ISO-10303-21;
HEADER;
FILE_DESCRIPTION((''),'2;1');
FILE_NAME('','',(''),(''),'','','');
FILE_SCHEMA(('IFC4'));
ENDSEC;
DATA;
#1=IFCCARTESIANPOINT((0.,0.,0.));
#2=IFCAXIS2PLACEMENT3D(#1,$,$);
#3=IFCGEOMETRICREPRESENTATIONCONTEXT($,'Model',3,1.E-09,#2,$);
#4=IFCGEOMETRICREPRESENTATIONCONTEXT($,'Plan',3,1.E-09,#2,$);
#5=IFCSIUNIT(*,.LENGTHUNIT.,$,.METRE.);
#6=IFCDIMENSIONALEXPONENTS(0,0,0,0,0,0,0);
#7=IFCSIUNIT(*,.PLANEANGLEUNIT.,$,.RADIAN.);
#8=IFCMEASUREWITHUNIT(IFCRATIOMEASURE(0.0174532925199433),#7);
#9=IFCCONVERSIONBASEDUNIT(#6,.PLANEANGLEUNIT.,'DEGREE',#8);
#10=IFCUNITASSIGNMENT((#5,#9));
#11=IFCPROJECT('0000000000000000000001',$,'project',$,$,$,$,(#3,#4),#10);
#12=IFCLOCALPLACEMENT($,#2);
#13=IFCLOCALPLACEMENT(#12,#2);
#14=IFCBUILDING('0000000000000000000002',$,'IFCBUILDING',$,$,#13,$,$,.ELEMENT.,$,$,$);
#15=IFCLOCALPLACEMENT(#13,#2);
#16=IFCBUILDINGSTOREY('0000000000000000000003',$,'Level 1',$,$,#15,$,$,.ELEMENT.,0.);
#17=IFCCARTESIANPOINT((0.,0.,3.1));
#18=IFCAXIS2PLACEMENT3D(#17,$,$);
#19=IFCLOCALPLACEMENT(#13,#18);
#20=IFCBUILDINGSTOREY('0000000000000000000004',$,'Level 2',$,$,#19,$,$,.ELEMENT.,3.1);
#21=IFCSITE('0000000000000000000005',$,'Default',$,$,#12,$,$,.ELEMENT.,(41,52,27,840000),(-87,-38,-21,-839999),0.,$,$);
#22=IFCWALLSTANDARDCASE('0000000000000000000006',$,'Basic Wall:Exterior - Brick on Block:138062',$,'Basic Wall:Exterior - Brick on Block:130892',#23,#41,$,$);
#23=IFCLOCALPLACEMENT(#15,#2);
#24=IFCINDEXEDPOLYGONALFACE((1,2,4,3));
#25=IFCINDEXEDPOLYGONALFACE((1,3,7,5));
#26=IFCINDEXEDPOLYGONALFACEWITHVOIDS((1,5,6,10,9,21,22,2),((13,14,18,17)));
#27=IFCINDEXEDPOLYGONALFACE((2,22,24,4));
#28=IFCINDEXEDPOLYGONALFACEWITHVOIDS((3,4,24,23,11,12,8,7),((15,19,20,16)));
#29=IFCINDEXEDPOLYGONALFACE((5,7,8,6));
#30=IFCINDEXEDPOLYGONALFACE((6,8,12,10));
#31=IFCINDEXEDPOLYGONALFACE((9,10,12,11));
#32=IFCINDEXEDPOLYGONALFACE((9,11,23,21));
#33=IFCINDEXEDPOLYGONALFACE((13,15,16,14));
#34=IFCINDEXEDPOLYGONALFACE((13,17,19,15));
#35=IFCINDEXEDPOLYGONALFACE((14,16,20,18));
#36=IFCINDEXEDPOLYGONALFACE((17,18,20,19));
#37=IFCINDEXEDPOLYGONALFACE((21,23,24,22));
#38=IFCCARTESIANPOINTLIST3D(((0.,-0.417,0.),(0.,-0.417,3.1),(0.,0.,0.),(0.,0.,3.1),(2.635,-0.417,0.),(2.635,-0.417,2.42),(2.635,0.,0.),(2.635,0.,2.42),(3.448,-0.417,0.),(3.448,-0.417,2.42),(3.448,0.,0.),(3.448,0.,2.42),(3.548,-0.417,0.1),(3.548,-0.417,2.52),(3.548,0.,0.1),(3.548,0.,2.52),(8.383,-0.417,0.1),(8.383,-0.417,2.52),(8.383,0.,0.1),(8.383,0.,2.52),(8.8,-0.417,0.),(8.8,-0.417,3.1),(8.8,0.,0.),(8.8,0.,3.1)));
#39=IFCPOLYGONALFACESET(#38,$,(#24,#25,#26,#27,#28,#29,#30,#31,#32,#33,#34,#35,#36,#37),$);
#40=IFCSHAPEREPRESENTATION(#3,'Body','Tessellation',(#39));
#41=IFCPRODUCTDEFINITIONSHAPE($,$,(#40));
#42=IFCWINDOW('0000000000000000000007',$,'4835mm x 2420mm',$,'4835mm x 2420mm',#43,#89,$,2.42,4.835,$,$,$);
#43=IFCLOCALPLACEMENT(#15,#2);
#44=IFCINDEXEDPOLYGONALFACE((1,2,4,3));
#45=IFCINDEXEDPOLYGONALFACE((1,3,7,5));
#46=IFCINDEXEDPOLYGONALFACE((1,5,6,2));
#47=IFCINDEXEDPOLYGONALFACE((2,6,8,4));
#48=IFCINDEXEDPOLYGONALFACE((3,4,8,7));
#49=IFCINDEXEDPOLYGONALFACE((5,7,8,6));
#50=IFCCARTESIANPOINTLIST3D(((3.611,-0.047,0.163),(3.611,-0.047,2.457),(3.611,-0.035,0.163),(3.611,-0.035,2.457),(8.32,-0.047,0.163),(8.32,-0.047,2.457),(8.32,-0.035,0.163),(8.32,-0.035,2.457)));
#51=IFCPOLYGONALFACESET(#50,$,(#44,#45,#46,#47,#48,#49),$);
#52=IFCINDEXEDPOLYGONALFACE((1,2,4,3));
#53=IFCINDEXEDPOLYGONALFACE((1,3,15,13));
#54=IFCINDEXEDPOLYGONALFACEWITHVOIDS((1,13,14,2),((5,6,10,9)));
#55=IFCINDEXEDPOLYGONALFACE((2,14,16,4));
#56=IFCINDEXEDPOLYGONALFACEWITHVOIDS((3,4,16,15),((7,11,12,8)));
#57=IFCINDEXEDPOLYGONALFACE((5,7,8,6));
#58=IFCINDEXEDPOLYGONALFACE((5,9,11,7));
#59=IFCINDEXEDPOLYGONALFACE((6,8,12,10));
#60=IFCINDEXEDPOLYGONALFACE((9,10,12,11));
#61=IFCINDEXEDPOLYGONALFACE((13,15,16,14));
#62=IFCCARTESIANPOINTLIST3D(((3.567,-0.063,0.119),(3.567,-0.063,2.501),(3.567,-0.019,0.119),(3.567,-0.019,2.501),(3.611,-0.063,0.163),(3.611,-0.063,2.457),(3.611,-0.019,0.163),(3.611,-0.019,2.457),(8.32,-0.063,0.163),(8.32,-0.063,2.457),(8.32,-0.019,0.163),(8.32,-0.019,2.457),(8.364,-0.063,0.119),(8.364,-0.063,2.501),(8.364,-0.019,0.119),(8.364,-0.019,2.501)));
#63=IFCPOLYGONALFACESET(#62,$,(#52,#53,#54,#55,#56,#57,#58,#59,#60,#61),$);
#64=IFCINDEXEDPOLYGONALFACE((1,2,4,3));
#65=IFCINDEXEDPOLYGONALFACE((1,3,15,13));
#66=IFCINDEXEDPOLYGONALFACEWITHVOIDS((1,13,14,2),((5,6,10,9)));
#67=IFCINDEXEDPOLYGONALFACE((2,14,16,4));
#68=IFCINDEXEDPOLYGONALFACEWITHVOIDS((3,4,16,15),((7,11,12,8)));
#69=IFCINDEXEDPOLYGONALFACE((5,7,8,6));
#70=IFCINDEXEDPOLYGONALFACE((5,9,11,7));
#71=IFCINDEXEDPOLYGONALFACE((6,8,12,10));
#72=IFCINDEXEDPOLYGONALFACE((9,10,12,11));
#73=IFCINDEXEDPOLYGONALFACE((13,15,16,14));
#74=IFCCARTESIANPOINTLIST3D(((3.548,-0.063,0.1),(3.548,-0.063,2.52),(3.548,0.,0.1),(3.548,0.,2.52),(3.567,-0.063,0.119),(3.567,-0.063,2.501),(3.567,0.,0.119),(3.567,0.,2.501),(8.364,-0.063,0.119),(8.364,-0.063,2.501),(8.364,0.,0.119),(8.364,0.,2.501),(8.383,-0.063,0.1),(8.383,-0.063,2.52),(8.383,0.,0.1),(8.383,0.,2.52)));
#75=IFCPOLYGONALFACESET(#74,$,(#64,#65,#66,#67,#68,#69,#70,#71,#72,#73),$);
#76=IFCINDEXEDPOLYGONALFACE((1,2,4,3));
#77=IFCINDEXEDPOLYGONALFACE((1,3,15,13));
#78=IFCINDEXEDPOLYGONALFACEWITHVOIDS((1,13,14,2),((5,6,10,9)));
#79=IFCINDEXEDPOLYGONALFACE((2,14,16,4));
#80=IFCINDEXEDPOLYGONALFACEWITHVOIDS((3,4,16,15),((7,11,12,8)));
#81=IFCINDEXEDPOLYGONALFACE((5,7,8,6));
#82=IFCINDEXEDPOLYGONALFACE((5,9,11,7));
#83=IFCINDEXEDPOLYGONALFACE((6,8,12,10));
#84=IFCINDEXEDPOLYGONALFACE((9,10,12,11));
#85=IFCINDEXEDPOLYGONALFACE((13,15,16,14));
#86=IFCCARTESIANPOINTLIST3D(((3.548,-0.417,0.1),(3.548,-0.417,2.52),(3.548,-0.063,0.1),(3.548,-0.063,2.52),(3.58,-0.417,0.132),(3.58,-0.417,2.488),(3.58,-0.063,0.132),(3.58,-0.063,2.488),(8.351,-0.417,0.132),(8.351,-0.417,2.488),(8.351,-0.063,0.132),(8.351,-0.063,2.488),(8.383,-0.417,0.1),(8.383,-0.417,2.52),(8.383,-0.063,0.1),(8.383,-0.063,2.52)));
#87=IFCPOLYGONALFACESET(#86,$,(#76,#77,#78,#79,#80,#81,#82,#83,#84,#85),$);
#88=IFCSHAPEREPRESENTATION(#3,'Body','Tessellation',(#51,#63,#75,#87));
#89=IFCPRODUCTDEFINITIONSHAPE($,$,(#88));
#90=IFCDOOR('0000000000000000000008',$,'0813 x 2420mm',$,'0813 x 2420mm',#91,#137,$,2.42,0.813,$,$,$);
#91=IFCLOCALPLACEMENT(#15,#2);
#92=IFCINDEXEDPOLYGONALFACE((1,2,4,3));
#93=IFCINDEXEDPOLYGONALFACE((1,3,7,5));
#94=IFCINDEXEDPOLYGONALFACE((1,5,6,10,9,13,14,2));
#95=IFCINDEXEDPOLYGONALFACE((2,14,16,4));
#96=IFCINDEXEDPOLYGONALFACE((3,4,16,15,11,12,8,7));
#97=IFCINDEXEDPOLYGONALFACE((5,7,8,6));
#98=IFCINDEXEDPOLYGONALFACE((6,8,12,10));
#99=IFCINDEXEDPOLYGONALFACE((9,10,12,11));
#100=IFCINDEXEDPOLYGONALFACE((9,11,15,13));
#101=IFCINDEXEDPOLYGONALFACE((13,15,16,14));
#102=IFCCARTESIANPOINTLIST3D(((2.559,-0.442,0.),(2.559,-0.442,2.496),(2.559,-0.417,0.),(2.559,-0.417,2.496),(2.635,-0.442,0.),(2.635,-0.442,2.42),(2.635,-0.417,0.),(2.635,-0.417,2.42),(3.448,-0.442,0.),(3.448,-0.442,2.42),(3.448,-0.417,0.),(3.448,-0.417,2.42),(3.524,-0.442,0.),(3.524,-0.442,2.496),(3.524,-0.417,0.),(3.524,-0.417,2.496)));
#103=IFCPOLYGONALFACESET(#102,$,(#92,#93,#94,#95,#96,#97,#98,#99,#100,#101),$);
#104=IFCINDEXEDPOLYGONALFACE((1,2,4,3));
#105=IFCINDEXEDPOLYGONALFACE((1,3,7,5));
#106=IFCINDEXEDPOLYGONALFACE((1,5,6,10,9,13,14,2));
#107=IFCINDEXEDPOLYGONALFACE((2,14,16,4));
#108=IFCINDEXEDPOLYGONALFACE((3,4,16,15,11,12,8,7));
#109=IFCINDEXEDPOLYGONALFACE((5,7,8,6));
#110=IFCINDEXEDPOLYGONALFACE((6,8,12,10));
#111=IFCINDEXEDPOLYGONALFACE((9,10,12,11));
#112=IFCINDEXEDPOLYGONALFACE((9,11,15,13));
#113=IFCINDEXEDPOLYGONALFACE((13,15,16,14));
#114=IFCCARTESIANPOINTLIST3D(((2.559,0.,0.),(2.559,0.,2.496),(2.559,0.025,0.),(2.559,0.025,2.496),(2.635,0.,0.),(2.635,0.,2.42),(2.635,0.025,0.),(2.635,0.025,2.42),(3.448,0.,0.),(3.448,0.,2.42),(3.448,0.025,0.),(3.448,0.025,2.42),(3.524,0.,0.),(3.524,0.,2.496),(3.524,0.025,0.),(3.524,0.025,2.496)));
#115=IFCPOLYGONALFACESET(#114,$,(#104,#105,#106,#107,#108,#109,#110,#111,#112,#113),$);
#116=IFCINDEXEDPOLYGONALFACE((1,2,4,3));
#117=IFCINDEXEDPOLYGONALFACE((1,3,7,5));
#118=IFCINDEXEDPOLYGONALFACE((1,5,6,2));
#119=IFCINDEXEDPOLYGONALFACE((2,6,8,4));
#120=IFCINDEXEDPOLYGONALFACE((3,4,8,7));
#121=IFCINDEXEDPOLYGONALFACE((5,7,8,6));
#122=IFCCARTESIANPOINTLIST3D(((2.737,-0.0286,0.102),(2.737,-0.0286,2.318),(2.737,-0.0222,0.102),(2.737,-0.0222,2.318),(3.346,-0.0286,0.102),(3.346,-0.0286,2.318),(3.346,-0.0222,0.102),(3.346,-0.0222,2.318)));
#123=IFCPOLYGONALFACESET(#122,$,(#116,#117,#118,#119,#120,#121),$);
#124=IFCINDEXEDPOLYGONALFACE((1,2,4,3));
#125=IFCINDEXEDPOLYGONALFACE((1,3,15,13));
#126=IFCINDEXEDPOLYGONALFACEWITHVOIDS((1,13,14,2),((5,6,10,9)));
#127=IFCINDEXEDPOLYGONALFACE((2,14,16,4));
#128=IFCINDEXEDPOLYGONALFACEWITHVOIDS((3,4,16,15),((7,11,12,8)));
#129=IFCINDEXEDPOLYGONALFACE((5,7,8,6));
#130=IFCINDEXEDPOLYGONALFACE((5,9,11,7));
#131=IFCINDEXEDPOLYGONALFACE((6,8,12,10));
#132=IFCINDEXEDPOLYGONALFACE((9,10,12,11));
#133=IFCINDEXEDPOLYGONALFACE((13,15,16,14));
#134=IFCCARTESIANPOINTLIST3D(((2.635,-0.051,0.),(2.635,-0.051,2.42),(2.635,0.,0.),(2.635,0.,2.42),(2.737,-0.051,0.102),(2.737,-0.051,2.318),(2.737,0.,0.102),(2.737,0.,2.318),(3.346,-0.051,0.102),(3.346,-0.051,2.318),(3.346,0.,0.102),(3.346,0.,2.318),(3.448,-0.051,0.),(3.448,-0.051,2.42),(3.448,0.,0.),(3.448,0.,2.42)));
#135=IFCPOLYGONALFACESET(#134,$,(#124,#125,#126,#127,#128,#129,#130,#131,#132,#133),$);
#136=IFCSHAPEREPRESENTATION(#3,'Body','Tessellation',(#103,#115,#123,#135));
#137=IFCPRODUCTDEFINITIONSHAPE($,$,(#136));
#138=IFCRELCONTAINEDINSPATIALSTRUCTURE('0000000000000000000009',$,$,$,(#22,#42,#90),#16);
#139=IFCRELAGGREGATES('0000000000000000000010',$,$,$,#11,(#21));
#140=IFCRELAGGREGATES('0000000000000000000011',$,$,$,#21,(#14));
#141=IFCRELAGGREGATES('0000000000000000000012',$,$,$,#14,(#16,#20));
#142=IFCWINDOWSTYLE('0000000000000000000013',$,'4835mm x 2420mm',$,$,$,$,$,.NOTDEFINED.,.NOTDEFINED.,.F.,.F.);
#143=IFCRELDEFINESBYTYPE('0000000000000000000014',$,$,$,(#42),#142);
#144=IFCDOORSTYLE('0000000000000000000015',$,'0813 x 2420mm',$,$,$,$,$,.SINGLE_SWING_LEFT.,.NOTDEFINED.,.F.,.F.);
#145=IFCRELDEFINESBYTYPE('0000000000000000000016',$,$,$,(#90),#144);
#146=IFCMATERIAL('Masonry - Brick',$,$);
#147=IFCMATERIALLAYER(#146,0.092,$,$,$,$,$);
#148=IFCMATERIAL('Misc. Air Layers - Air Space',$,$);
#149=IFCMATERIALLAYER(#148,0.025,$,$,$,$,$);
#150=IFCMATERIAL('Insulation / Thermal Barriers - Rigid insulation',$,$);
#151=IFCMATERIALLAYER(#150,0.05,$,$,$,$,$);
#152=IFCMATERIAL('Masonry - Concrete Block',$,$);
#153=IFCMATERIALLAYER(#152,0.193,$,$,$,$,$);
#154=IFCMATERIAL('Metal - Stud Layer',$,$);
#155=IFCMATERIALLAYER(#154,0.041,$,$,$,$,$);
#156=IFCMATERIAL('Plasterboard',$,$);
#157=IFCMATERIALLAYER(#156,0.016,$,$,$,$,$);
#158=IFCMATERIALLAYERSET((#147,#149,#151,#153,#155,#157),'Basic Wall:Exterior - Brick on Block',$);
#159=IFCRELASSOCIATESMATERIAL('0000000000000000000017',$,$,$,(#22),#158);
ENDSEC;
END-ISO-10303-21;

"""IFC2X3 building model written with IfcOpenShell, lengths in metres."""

from ifc_helpers import new_model, entity, si_unit, converted_unit, frame, frame_2d, origin, origin_2d_with_axis, place, context, project, spatial, polyline, rectangle, outline, extrude, source, transform, mapped, material, layer, layer_set, layer_usage, type_object, type_shapes, element, fill, save


model = new_model("IFC2X3")

# Units and contexts
model_context = context("Model", 3, precision=1e-09, world=origin())
plan_context = context("Plan", 3, precision=1e-09, world=origin())
ifc_project = project(units=[si_unit("LENGTHUNIT", "METRE"), converted_unit("PLANEANGLEUNIT", "DEGREE", entity("IfcRatioMeasure", 0.0174532925199433), si_unit("PLANEANGLEUNIT", "RADIAN"), dimensions=[0, 0, 0, 0, 0, 0, 0])], contexts=[model_context, plan_context])

# Site, building, storey
site_placement = place(None, origin())
site = spatial("IfcSite", under=ifc_project, at=site_placement, Name="Default", CompositionType="ELEMENT", RefLatitude=(41, 52, 27, 840000), RefLongitude=(-87, -38, -21, -839999), RefElevation=0.0)
building_placement = place(site_placement, origin())
building = spatial("IfcBuilding", under=site, at=building_placement, Name="IFCBUILDING", CompositionType="ELEMENT")
storey_1_placement = place(building_placement, origin())
storey_1 = spatial("IfcBuildingStorey", under=building, at=storey_1_placement, Name="Level 1", CompositionType="ELEMENT", Elevation=0.0)

# Wall, openings, window, door
ifc_material_1 = material(Name="Masonry - Brick")
ifc_layer_1 = layer(ifc_material_1, 0.092)
ifc_material_2 = material(Name="Misc. Air Layers - Air Space")
ifc_layer_2 = layer(ifc_material_2, 0.025)
ifc_material_3 = material(Name="Insulation / Thermal Barriers - Rigid insulation")
ifc_layer_3 = layer(ifc_material_3, 0.05)
ifc_material_4 = material(Name="Masonry - Concrete Block")
ifc_layer_4 = layer(ifc_material_4, 0.193)
ifc_material_5 = material(Name="Metal - Stud Layer")
ifc_layer_5 = layer(ifc_material_5, 0.041)
ifc_material_6 = material(Name="Plasterboard")
ifc_layer_6 = layer(ifc_material_6, 0.016)
ifc_layer_set_1 = layer_set([ifc_layer_1, ifc_layer_2, ifc_layer_3, ifc_layer_4, ifc_layer_5, ifc_layer_6], Name="Basic Wall:Exterior - Brick on Block")
ifc_layer_usage_1 = layer_usage(ifc_layer_set_1, "AXIS2", "NEGATIVE", 0.2085)
wall_1_placement = place(storey_1_placement, frame((0.0, -0.2085, 0.0)))
wall_1 = element("IfcWallStandardCase", 1, at=wall_1_placement, inside=storey_1, material=ifc_layer_usage_1, Name="Basic Wall:Exterior - Brick on Block:138062", ObjectType="Basic Wall:Exterior - Brick on Block:130892", context=model_context, shape_type="SweptSolid", body=[
    extrude(rectangle(XDim=8.8, YDim=0.417, at=frame_2d((4.4, 0.0), x_axis=(-1.0, 0.0))), origin(), (0.0, 0.0, 1.0), 3.1),
])
opening_1_placement = place(wall_1_placement, frame((3.548, -0.2085, 0.1)))
opening_1 = element("IfcOpeningElement", 2, at=opening_1_placement, cuts=wall_1, ObjectType="Opening", context=model_context, shape_type="SweptSolid", body=[
    extrude(rectangle(XDim=2.42, YDim=4.835, at=frame_2d((1.21, 2.4175), x_axis=(1.0, 0.0))), frame((0.0, 0.0, 0.0), z_axis=(0.0, 1.0, 0.0), x_axis=(0.0, 0.0, 1.0)), (0.0, 0.0, 1.0), 0.417),
])
opening_2_placement = place(wall_1_placement, frame((2.635, -0.2085, 0.0)))
opening_2 = element("IfcOpeningElement", 3, at=opening_2_placement, cuts=wall_1, ObjectType="Opening", context=model_context, shape_type="SweptSolid", body=[
    extrude(rectangle(XDim=0.813, YDim=2.42, at=frame_2d((1.21, 0.4065), x_axis=(0.0, -1.0))), frame((0.0, 0.0, 0.0), z_axis=(0.0, 1.0, 0.0), x_axis=(0.0, 0.0, 1.0)), (0.0, 0.0, 1.0), 0.417),
])
window_style_1 = type_object("IfcWindowStyle", Name="4835mm x 2420mm", ConstructionType="NOTDEFINED", OperationType="NOTDEFINED", ParameterTakesPrecedence=False, Sizeable=False)
shared_shape_1 = source(origin(), model_context, "Body", "SweptSolid", [
    extrude(rectangle(XDim=0.012, YDim=4.709, at=origin_2d_with_axis()), frame((2.4175, 0.376, 0.063), z_axis=(0.0, 0.0, 1.0), x_axis=(0.0, -1.0, 0.0)), (0.0, 0.0, 1.0), 2.294),
    extrude(outline(polyline([(-2.3985, -1.191), (2.3985, -1.191), (2.3985, 1.191), (-2.3985, 1.191), (-2.3985, -1.191)]), holes=[polyline([(-2.3545, -1.147), (-2.3545, 1.147), (2.3545, 1.147), (2.3545, -1.147), (-2.3545, -1.147)])]), frame((2.4175, 0.354, 1.21), z_axis=(0.0, 1.0, 0.0), x_axis=(1.0, 0.0, 0.0)), (0.0, 0.0, 1.0), 0.044),
    extrude(outline(polyline([(-2.4175, -1.21), (2.4175, -1.21), (2.4175, 1.21), (-2.4175, 1.21), (-2.4175, -1.21)]), holes=[polyline([(-2.3985, -1.191), (-2.3985, 1.191), (2.3985, 1.191), (2.3985, -1.191), (-2.3985, -1.191)])]), frame((2.4175, 0.354, 1.21), z_axis=(0.0, 1.0, 0.0), x_axis=(1.0, 0.0, 0.0)), (0.0, 0.0, 1.0), 0.063),
    extrude(outline(polyline([(-2.4175, -1.21), (2.4175, -1.21), (2.4175, 1.21), (-2.4175, 1.21), (-2.4175, -1.21)]), holes=[polyline([(-2.3855, -1.178), (-2.3855, 1.178), (2.3855, 1.178), (2.3855, -1.178), (-2.3855, -1.178)])]), frame((2.4175, 0.0, 1.21), z_axis=(0.0, 1.0, 0.0), x_axis=(1.0, 0.0, 0.0)), (0.0, 0.0, 1.0), 0.354),
])
type_shapes(window_style_1, [shared_shape_1])
window_1_placement = place(opening_1_placement, origin())
window_1 = element("IfcWindow", 4, at=window_1_placement, inside=storey_1, type_object=window_style_1, Name="4835mm x 2420mm", ObjectType="4835mm x 2420mm", OverallHeight=2.42, OverallWidth=4.835, context=model_context, shape_type="MappedRepresentation", body=[
    mapped(shared_shape_1, transform((0.0, 0.0, 0.0), scale=1.0)),
])
fill(opening_1, window_1)
door_style_1 = type_object("IfcDoorStyle", Name="0813 x 2420mm", ConstructionType="NOTDEFINED", OperationType="SINGLE_SWING_LEFT", ParameterTakesPrecedence=False, Sizeable=False)
shared_shape_2 = source(origin(), model_context, "Body", "SweptSolid", [
    extrude(outline(polyline([(-0.4065, -1.191), (-0.4065, 1.229), (-0.4825, 1.229), (-0.4825, -1.267), (0.4825, -1.267), (0.4825, 1.229), (0.4065, 1.229), (0.4065, -1.191), (-0.4065, -1.191)])), frame((0.4065, 0.0, 1.229), z_axis=(0.0, 1.0, 0.0), x_axis=(1.0, 0.0, 0.0)), (0.0, 0.0, -1.0), 0.025),
    extrude(outline(polyline([(-0.4065, -1.191), (-0.4065, 1.229), (-0.4825, 1.229), (-0.4825, -1.267), (0.4825, -1.267), (0.4825, 1.229), (0.4065, 1.229), (0.4065, -1.191), (-0.4065, -1.191)])), frame((0.4065, 0.442, 1.229), z_axis=(0.0, 1.0, 0.0), x_axis=(1.0, 0.0, 0.0)), (0.0, 0.0, -1.0), 0.025),
    extrude(rectangle(XDim=0.609, YDim=0.0064, at=origin_2d_with_axis()), frame((0.4065, 0.3916, 0.102)), (0.0, 0.0, 1.0), 2.216),
    extrude(outline(polyline([(-1.21, -0.4065), (1.21, -0.4065), (1.21, 0.4065), (-1.21, 0.4065), (-1.21, -0.4065)]), holes=[polyline([(-1.108, 0.3045), (1.108, 0.3045), (1.108, -0.3045), (-1.108, -0.3045), (-1.108, 0.3045)])]), frame((0.4065, 0.417, 1.21), z_axis=(0.0, -1.0, 0.0), x_axis=(0.0, 0.0, -1.0)), (0.0, 0.0, 1.0), 0.051),
])
type_shapes(door_style_1, [shared_shape_2])
door_1_placement = place(opening_2_placement, origin())
door_1 = element("IfcDoor", 5, at=door_1_placement, inside=storey_1, type_object=door_style_1, Name="0813 x 2420mm", ObjectType="0813 x 2420mm", OverallHeight=2.42, OverallWidth=0.813, context=model_context, shape_type="MappedRepresentation", body=[
    mapped(shared_shape_2, transform((0.0, 0.0, 0.0), scale=1.0)),
])
fill(opening_2, door_1)

# Shared definitions
storey_2_placement = place(building_placement, frame((0.0, 0.0, 3.1)))
storey_2 = spatial("IfcBuildingStorey", under=building, at=storey_2_placement, Name="Level 2", CompositionType="ELEMENT", Elevation=3.1)

save(model, "model.ifc")
